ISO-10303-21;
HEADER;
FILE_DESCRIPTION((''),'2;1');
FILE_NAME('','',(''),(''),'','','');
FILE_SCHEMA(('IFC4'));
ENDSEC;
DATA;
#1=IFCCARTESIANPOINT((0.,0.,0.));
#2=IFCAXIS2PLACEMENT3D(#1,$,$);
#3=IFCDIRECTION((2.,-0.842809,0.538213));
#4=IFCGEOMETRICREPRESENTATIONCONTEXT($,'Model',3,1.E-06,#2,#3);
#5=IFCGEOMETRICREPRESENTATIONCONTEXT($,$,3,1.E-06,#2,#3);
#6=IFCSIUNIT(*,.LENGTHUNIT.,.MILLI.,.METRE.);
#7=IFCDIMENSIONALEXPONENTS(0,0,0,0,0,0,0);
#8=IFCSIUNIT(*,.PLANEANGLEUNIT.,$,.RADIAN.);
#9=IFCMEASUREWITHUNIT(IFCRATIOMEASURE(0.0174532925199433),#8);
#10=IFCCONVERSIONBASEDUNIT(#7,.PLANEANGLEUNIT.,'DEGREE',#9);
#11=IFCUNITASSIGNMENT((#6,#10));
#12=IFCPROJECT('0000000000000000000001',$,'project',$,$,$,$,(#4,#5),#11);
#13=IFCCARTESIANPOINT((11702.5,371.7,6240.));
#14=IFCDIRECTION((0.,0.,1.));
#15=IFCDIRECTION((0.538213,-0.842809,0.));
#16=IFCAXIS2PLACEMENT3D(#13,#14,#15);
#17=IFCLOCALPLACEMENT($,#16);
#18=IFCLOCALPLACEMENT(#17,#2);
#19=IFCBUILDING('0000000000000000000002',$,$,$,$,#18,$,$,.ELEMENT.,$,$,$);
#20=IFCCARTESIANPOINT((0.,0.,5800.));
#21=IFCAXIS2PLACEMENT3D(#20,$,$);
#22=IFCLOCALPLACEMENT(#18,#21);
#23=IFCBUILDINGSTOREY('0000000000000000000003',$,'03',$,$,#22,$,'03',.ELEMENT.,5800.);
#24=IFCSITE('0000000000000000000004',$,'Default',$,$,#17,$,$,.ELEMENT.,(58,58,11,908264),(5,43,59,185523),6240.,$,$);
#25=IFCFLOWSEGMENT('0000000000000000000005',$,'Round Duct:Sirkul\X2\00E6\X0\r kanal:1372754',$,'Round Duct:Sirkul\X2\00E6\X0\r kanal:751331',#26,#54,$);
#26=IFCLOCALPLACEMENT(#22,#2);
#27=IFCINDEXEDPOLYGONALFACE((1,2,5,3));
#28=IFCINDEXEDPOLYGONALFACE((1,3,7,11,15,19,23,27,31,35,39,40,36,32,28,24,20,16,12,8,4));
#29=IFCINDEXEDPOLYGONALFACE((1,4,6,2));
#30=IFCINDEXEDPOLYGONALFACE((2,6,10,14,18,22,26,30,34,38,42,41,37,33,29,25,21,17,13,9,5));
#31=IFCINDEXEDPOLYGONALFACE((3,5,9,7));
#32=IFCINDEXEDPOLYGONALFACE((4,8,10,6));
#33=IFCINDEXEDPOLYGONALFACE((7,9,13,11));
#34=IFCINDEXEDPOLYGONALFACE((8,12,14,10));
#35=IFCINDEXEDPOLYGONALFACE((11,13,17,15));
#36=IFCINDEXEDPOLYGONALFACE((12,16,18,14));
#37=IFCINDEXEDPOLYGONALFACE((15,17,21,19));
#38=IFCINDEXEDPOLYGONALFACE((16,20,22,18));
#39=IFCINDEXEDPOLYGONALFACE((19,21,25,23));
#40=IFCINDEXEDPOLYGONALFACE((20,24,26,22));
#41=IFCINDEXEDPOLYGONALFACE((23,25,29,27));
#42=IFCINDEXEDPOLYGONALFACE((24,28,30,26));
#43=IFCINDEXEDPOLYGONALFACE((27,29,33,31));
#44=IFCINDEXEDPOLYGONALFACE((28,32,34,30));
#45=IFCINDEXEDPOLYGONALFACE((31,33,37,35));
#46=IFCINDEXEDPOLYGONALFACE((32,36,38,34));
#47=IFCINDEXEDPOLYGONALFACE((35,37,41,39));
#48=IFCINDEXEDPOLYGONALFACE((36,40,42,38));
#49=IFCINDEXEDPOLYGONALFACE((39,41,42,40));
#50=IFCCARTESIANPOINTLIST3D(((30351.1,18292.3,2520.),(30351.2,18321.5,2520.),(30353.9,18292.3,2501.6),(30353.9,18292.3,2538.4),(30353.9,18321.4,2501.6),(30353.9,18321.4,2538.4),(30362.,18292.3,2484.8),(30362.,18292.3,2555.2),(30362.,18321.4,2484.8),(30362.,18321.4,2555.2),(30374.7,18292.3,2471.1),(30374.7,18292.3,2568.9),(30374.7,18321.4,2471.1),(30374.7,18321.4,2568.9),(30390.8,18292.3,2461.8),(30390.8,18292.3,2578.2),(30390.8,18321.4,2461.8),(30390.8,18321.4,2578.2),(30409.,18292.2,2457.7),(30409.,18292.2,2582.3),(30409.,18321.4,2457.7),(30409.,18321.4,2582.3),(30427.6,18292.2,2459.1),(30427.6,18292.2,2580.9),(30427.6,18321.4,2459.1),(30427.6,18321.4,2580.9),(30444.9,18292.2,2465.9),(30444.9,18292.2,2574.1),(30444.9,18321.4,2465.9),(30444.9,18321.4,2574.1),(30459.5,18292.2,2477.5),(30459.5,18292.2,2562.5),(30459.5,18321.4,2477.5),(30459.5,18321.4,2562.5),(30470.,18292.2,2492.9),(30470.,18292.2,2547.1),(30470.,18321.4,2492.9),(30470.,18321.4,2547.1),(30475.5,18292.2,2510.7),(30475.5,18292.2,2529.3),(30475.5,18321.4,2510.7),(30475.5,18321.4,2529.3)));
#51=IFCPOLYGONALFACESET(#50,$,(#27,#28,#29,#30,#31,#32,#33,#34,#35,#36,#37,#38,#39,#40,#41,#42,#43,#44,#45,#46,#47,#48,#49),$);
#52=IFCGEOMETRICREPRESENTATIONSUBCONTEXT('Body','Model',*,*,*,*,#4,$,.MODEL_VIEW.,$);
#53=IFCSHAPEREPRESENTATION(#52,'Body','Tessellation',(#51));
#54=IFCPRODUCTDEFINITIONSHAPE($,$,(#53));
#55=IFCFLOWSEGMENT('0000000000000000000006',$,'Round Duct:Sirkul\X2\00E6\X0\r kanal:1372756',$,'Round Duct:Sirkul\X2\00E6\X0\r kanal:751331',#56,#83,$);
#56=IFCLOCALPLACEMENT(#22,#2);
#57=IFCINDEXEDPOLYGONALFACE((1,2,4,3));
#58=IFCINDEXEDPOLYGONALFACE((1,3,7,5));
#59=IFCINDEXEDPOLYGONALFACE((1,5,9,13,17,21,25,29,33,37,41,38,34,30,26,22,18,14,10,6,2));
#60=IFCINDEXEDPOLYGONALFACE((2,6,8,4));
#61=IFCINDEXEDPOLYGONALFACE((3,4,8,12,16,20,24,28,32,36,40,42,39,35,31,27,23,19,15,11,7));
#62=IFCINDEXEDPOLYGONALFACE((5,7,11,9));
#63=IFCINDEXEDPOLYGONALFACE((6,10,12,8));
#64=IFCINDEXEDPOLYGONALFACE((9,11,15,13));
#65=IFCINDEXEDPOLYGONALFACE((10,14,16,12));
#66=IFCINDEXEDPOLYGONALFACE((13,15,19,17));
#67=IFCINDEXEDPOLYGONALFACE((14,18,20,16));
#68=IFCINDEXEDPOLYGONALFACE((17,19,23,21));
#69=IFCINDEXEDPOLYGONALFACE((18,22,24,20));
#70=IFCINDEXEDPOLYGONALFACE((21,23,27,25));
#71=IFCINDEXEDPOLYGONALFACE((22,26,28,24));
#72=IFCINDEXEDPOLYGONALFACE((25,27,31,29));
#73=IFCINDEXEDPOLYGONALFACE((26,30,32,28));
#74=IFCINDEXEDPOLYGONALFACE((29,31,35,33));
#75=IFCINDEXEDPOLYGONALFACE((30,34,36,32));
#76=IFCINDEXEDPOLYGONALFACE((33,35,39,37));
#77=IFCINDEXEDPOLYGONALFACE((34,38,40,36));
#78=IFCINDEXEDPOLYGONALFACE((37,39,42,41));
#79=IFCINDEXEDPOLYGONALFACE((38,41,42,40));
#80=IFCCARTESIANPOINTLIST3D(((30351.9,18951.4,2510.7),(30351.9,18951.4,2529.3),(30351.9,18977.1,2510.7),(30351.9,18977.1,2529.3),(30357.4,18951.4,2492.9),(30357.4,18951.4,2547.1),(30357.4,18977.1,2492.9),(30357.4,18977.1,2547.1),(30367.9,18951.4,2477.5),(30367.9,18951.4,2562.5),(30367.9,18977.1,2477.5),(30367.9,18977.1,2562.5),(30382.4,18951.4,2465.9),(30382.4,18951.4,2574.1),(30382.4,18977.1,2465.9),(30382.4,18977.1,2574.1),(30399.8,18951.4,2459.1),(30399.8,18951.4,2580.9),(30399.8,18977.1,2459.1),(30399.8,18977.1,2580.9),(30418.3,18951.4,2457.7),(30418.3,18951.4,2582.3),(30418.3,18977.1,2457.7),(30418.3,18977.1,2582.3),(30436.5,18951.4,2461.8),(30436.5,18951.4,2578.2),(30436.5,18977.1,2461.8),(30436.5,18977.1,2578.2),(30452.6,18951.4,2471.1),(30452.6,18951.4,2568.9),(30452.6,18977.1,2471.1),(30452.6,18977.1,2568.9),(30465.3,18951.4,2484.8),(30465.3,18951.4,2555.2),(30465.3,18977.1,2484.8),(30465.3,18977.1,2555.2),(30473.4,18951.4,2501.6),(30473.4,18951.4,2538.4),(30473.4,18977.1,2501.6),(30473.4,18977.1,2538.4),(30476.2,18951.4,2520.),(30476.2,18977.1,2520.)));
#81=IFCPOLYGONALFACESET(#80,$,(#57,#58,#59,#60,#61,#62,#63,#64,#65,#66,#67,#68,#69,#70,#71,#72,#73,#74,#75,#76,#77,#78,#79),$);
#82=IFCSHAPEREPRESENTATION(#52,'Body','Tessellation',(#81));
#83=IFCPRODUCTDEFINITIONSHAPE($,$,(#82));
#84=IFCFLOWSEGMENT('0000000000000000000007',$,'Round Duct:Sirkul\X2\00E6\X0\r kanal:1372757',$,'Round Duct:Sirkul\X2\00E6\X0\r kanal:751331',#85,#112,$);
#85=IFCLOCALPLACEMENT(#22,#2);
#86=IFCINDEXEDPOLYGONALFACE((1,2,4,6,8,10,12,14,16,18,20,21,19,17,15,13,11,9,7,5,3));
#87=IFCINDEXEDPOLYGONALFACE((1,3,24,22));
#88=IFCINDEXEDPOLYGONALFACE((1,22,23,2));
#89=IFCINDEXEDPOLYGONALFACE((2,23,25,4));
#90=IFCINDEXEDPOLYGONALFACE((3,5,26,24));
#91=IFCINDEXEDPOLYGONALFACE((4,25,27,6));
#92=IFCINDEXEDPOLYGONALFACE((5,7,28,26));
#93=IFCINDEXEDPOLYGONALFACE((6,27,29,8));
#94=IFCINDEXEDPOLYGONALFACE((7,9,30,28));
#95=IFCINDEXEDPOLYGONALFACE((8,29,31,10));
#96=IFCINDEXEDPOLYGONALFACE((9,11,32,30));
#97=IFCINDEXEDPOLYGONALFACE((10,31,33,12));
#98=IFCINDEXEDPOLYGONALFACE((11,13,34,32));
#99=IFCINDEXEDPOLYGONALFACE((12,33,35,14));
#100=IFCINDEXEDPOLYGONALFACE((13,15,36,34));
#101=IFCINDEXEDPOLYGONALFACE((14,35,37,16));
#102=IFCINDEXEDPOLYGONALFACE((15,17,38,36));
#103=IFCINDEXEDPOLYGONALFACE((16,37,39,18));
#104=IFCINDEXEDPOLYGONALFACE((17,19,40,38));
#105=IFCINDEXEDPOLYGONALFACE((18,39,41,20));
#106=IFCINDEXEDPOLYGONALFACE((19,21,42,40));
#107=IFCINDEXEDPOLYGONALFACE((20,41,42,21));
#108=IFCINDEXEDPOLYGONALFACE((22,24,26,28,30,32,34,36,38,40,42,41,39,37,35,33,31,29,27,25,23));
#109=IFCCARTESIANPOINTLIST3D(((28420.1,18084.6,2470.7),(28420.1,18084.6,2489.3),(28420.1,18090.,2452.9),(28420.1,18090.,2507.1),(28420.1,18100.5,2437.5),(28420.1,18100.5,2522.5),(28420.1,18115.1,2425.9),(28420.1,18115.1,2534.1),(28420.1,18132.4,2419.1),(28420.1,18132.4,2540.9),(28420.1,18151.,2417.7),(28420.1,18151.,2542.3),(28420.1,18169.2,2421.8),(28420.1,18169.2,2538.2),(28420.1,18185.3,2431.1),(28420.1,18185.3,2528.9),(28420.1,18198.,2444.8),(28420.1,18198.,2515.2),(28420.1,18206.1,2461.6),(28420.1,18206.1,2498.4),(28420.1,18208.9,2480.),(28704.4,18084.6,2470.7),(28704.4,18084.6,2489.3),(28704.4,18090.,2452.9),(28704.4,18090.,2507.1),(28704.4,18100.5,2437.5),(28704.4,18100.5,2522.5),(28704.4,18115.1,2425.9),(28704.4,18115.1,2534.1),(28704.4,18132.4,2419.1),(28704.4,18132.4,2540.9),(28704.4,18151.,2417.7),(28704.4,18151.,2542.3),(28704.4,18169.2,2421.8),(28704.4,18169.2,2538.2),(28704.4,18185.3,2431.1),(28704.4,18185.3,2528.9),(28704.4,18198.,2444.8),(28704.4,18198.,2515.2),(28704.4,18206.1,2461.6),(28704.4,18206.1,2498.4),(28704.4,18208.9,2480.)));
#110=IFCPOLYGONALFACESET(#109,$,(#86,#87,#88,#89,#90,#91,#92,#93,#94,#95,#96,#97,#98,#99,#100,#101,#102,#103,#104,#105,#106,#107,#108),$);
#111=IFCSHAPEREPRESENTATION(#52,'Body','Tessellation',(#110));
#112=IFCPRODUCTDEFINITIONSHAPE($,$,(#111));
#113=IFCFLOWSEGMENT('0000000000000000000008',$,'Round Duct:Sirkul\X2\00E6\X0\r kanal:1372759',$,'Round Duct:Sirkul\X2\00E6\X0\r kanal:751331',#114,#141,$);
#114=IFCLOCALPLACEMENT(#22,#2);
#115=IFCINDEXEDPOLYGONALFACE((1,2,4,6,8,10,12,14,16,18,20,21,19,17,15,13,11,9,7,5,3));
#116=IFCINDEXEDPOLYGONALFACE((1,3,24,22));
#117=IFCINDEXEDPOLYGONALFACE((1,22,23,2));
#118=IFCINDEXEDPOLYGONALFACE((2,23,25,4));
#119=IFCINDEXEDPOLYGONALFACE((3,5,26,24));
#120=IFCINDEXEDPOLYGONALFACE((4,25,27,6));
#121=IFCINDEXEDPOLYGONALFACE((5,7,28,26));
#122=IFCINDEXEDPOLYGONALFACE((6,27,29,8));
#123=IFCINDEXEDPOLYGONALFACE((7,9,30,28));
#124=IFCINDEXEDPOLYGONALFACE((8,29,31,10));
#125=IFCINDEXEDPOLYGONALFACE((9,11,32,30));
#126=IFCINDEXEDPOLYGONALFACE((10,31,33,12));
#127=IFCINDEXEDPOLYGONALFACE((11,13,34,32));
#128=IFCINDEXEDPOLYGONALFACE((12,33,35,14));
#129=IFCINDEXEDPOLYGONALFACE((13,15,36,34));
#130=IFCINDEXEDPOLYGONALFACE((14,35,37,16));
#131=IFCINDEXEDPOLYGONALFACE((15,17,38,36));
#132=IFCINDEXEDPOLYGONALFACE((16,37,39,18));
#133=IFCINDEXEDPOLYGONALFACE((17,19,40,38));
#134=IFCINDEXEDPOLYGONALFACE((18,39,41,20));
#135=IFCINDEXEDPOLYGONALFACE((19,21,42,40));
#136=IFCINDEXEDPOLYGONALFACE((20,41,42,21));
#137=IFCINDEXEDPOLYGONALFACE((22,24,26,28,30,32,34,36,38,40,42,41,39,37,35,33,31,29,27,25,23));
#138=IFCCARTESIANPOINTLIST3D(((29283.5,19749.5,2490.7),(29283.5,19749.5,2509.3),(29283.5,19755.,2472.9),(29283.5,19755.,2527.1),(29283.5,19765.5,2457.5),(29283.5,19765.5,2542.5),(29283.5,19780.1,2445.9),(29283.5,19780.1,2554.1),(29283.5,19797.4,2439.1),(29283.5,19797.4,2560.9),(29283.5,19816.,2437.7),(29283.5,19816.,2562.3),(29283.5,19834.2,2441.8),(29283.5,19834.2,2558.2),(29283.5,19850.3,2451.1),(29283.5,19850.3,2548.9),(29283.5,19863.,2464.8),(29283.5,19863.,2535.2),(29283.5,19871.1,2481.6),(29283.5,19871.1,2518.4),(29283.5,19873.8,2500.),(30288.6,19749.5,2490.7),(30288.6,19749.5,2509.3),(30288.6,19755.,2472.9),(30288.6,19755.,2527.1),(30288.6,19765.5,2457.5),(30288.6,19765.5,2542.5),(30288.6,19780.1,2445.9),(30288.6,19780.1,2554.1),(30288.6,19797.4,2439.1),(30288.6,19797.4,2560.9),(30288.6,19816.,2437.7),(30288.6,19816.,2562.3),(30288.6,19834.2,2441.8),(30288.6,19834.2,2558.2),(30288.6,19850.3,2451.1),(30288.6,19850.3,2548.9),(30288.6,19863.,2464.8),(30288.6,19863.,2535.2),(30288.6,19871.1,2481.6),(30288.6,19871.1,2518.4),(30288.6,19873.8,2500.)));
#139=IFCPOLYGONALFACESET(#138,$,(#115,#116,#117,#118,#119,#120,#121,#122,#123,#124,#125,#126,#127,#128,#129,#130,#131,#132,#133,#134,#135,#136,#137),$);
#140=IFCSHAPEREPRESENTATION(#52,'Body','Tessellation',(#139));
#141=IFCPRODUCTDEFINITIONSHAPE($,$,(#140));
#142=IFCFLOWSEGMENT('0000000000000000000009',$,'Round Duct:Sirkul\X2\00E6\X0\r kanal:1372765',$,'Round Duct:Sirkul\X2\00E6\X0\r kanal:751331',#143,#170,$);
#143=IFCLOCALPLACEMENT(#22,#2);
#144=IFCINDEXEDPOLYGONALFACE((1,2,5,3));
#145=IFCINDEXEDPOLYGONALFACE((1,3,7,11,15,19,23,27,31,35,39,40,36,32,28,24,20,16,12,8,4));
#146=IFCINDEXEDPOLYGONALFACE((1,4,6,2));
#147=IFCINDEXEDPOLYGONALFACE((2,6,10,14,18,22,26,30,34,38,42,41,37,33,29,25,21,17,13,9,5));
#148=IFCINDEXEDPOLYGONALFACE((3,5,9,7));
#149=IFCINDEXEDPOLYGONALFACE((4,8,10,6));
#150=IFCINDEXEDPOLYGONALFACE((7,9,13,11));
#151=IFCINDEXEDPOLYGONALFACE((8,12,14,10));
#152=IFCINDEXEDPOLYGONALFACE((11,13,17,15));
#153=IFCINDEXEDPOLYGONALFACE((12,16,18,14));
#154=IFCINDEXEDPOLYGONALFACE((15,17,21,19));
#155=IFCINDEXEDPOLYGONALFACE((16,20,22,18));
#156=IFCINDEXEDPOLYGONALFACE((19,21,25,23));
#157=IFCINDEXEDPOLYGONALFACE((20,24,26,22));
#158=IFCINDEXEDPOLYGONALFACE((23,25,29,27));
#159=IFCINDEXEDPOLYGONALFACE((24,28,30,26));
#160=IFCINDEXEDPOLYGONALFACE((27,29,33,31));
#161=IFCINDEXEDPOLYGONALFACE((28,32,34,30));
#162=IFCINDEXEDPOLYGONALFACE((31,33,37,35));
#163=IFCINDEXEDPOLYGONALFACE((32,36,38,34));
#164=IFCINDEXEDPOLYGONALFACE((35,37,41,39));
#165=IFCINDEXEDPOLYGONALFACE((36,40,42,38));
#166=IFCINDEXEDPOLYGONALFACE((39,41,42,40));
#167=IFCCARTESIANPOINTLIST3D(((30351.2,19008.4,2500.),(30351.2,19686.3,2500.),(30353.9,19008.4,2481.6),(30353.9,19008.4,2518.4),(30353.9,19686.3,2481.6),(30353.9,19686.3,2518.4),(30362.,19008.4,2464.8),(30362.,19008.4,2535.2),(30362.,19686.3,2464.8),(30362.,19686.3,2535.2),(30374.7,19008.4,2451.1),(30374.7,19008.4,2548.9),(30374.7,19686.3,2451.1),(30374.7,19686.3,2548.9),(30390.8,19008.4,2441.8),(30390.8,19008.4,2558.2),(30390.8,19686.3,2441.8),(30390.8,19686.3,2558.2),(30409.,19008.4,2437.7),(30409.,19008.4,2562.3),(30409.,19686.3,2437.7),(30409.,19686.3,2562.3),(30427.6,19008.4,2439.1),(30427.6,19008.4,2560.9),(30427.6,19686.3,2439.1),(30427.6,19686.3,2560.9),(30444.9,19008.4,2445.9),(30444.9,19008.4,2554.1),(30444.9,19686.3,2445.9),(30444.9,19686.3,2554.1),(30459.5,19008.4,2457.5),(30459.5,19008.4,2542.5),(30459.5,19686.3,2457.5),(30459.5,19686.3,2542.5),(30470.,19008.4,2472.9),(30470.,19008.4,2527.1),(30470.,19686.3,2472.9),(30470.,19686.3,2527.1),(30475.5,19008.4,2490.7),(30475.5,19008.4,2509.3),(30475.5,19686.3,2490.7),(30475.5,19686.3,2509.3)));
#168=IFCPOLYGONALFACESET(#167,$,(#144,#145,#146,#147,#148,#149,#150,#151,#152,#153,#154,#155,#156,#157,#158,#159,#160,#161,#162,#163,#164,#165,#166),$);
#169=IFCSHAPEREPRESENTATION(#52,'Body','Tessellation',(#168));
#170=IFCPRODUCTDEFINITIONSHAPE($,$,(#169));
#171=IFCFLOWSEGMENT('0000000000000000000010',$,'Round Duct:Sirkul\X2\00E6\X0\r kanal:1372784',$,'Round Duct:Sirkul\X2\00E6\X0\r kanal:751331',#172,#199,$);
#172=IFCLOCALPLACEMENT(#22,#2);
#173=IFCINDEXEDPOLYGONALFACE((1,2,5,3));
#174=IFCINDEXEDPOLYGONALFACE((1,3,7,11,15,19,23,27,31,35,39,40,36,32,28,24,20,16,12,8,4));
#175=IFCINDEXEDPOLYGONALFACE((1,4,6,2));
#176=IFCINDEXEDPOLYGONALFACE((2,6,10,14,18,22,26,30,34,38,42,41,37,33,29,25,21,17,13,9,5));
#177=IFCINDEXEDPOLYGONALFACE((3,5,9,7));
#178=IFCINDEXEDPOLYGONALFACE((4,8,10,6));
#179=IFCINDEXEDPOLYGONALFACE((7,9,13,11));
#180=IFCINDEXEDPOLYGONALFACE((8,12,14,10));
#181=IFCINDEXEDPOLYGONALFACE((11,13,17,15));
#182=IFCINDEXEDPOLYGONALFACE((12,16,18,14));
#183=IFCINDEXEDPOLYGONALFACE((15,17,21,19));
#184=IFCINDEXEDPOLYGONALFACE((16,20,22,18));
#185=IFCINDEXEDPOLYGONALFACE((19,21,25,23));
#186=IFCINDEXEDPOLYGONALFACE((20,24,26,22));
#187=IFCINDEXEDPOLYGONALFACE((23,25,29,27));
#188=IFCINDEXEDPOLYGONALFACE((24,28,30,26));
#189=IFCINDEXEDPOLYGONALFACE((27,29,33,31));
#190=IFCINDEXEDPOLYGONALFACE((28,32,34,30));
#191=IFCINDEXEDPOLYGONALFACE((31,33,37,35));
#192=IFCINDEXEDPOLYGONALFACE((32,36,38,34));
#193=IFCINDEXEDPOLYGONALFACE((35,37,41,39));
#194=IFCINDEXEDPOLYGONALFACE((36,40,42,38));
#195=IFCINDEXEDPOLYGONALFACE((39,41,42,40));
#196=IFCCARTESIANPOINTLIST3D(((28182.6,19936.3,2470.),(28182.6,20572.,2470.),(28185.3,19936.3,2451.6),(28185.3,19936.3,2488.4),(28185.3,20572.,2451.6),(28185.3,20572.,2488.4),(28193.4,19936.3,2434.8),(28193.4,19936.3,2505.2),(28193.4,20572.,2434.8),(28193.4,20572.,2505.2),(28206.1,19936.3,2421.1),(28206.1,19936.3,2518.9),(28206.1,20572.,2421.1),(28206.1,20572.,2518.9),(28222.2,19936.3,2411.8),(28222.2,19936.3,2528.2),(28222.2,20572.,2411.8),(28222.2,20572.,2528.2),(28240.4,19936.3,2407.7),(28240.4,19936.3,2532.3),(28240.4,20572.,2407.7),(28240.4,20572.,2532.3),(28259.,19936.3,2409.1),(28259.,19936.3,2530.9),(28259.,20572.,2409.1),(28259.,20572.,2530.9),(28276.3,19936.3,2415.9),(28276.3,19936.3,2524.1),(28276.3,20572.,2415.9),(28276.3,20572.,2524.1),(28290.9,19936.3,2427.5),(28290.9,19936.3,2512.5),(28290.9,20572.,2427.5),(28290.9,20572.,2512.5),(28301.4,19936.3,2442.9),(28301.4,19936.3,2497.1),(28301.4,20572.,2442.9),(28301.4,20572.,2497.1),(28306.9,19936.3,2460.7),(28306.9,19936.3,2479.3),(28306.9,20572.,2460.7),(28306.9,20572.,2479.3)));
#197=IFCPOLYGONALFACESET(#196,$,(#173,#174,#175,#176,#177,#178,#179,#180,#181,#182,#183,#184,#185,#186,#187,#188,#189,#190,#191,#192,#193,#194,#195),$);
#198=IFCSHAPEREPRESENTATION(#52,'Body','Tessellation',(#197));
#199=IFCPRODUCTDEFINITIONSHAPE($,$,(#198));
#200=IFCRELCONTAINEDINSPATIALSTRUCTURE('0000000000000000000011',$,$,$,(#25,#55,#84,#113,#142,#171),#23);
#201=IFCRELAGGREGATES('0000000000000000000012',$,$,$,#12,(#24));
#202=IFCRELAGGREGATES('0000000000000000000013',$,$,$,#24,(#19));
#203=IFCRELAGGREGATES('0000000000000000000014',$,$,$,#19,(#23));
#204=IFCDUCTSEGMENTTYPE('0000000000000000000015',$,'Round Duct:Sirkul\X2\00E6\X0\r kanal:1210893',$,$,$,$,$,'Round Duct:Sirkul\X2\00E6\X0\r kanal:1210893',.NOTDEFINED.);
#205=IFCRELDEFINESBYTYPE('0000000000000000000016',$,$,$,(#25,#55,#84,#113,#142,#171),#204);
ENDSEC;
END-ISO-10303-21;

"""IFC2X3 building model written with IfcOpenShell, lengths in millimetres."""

from ifc_helpers import new_model, entity, si_unit, converted_unit, direction, frame, frame_2d, origin, origin_2d_with_axis, place, context, subcontext, project, spatial, circle, extrude, type_object, element, save


model = new_model("IFC2X3")

# Units and contexts
model_context = context("Model", 3, precision=1e-06, world=origin(), true_north=direction((2.0, -0.842809, 0.538213)))
context_of_model = context(None, 3, precision=1e-06, world=origin(), true_north=direction((2.0, -0.842809, 0.538213)))
body_context = subcontext(model_context, "Body", "Model", "MODEL_VIEW")
ifc_project = project(units=[si_unit("LENGTHUNIT", "METRE", prefix="MILLI"), converted_unit("PLANEANGLEUNIT", "DEGREE", entity("IfcRatioMeasure", 0.0174532925199433), si_unit("PLANEANGLEUNIT", "RADIAN"), dimensions=[0, 0, 0, 0, 0, 0, 0])], contexts=[model_context, context_of_model])

# Site, building, storey
site_placement = place(None, frame((11702.5, 371.7, 6240.0), z_axis=(0.0, 0.0, 1.0), x_axis=(0.538213, -0.842809, 0.0)))
site = spatial("IfcSite", under=ifc_project, at=site_placement, Name="Default", CompositionType="ELEMENT", RefLatitude=(58, 58, 11, 908264), RefLongitude=(5, 43, 59, 185523), RefElevation=6240.0)
building_placement = place(site_placement, origin())
building = spatial("IfcBuilding", under=site, at=building_placement, CompositionType="ELEMENT")
storey_placement = place(building_placement, frame((0.0, 0.0, 5800.0)))
storey = spatial("IfcBuildingStorey", under=building, at=storey_placement, Name="03", LongName="03", CompositionType="ELEMENT", Elevation=5800.0)

# Flow segments
duct_segment_type_1 = type_object("IfcDuctSegmentType", Name="Round Duct:Sirkulær kanal:1210893", ElementType="Round Duct:Sirkulær kanal:1210893", PredefinedType="NOTDEFINED")
flow_segment_1_placement = place(storey_placement, origin())
element("IfcFlowSegment", 1, at=flow_segment_1_placement, inside=storey, type_object=duct_segment_type_1, Name="Round Duct:Sirkulær kanal:1372754", ObjectType="Round Duct:Sirkulær kanal:751331", context=body_context, shape_type="SweptSolid", body=[
    extrude(circle(Radius=62.5, at=frame_2d((0.0, 0.0), x_axis=(1.0, 0.0))), frame((30413.6, 18292.2, 2520.0), z_axis=(0.000626, 1.0, 0.0), x_axis=(-1.0, 0.000626, 0.0)), (0.0, 0.0, 1.0), 29.2),
])
flow_segment_2_placement = place(storey_placement, origin())
element("IfcFlowSegment", 2, at=flow_segment_2_placement, inside=storey, type_object=duct_segment_type_1, Name="Round Duct:Sirkulær kanal:1372756", ObjectType="Round Duct:Sirkulær kanal:751331", context=body_context, shape_type="SweptSolid", body=[
    extrude(circle(Radius=62.5, at=frame_2d((0.0, 0.0), x_axis=(1.0, 0.0))), frame((30413.7, 18951.4, 2520.0), z_axis=(0.0, 1.0, 0.0), x_axis=(1.0, 0.0, 0.0)), (0.0, 0.0, 1.0), 25.7),
])
flow_segment_3_placement = place(storey_placement, origin())
element("IfcFlowSegment", 3, at=flow_segment_3_placement, inside=storey, type_object=duct_segment_type_1, Name="Round Duct:Sirkulær kanal:1372757", ObjectType="Round Duct:Sirkulær kanal:751331", context=body_context, shape_type="SweptSolid", body=[
    extrude(circle(Radius=62.5, at=frame_2d((0.0, 0.0), x_axis=(1.0, 0.0))), frame((28420.1, 18146.4, 2480.0), z_axis=(1.0, 0.0, 0.0), x_axis=(0.0, 1.0, 0.0)), (0.0, 0.0, 1.0), 284.4),
])
flow_segment_4_placement = place(storey_placement, origin())
element("IfcFlowSegment", 4, at=flow_segment_4_placement, inside=storey, type_object=duct_segment_type_1, Name="Round Duct:Sirkulær kanal:1372759", ObjectType="Round Duct:Sirkulær kanal:751331", context=body_context, shape_type="SweptSolid", body=[
    extrude(circle(Radius=62.5, at=frame_2d((0.0, 0.0), x_axis=(1.0, 0.0))), frame((29283.5, 19811.3, 2500.0), z_axis=(1.0, 0.0, 0.0), x_axis=(0.0, 1.0, 0.0)), (0.0, 0.0, 1.0), 1005.1),
])
flow_segment_5_placement = place(storey_placement, origin())
element("IfcFlowSegment", 5, at=flow_segment_5_placement, inside=storey, type_object=duct_segment_type_1, Name="Round Duct:Sirkulær kanal:1372765", ObjectType="Round Duct:Sirkulær kanal:751331", context=body_context, shape_type="SweptSolid", body=[
    extrude(circle(Radius=62.5, at=frame_2d((0.0, 0.0), x_axis=(1.0, 0.0))), frame((30413.7, 19008.4, 2500.0), z_axis=(0.0, 1.0, 0.0), x_axis=(-1.0, 0.0, 0.0)), (0.0, 0.0, 1.0), 677.9),
])
flow_segment_6_placement = place(storey_placement, origin())
element("IfcFlowSegment", 6, at=flow_segment_6_placement, inside=storey, type_object=duct_segment_type_1, Name="Round Duct:Sirkulær kanal:1372784", ObjectType="Round Duct:Sirkulær kanal:751331", context=body_context, shape_type="SweptSolid", body=[
    extrude(circle(Radius=62.5, at=origin_2d_with_axis()), frame((28245.1, 19936.3, 2470.0), z_axis=(0.0, 1.0, 0.0), x_axis=(-1.0, 0.0, 0.0)), (0.0, 0.0, 1.0), 635.7),
])

save(model, "model.ifc")
